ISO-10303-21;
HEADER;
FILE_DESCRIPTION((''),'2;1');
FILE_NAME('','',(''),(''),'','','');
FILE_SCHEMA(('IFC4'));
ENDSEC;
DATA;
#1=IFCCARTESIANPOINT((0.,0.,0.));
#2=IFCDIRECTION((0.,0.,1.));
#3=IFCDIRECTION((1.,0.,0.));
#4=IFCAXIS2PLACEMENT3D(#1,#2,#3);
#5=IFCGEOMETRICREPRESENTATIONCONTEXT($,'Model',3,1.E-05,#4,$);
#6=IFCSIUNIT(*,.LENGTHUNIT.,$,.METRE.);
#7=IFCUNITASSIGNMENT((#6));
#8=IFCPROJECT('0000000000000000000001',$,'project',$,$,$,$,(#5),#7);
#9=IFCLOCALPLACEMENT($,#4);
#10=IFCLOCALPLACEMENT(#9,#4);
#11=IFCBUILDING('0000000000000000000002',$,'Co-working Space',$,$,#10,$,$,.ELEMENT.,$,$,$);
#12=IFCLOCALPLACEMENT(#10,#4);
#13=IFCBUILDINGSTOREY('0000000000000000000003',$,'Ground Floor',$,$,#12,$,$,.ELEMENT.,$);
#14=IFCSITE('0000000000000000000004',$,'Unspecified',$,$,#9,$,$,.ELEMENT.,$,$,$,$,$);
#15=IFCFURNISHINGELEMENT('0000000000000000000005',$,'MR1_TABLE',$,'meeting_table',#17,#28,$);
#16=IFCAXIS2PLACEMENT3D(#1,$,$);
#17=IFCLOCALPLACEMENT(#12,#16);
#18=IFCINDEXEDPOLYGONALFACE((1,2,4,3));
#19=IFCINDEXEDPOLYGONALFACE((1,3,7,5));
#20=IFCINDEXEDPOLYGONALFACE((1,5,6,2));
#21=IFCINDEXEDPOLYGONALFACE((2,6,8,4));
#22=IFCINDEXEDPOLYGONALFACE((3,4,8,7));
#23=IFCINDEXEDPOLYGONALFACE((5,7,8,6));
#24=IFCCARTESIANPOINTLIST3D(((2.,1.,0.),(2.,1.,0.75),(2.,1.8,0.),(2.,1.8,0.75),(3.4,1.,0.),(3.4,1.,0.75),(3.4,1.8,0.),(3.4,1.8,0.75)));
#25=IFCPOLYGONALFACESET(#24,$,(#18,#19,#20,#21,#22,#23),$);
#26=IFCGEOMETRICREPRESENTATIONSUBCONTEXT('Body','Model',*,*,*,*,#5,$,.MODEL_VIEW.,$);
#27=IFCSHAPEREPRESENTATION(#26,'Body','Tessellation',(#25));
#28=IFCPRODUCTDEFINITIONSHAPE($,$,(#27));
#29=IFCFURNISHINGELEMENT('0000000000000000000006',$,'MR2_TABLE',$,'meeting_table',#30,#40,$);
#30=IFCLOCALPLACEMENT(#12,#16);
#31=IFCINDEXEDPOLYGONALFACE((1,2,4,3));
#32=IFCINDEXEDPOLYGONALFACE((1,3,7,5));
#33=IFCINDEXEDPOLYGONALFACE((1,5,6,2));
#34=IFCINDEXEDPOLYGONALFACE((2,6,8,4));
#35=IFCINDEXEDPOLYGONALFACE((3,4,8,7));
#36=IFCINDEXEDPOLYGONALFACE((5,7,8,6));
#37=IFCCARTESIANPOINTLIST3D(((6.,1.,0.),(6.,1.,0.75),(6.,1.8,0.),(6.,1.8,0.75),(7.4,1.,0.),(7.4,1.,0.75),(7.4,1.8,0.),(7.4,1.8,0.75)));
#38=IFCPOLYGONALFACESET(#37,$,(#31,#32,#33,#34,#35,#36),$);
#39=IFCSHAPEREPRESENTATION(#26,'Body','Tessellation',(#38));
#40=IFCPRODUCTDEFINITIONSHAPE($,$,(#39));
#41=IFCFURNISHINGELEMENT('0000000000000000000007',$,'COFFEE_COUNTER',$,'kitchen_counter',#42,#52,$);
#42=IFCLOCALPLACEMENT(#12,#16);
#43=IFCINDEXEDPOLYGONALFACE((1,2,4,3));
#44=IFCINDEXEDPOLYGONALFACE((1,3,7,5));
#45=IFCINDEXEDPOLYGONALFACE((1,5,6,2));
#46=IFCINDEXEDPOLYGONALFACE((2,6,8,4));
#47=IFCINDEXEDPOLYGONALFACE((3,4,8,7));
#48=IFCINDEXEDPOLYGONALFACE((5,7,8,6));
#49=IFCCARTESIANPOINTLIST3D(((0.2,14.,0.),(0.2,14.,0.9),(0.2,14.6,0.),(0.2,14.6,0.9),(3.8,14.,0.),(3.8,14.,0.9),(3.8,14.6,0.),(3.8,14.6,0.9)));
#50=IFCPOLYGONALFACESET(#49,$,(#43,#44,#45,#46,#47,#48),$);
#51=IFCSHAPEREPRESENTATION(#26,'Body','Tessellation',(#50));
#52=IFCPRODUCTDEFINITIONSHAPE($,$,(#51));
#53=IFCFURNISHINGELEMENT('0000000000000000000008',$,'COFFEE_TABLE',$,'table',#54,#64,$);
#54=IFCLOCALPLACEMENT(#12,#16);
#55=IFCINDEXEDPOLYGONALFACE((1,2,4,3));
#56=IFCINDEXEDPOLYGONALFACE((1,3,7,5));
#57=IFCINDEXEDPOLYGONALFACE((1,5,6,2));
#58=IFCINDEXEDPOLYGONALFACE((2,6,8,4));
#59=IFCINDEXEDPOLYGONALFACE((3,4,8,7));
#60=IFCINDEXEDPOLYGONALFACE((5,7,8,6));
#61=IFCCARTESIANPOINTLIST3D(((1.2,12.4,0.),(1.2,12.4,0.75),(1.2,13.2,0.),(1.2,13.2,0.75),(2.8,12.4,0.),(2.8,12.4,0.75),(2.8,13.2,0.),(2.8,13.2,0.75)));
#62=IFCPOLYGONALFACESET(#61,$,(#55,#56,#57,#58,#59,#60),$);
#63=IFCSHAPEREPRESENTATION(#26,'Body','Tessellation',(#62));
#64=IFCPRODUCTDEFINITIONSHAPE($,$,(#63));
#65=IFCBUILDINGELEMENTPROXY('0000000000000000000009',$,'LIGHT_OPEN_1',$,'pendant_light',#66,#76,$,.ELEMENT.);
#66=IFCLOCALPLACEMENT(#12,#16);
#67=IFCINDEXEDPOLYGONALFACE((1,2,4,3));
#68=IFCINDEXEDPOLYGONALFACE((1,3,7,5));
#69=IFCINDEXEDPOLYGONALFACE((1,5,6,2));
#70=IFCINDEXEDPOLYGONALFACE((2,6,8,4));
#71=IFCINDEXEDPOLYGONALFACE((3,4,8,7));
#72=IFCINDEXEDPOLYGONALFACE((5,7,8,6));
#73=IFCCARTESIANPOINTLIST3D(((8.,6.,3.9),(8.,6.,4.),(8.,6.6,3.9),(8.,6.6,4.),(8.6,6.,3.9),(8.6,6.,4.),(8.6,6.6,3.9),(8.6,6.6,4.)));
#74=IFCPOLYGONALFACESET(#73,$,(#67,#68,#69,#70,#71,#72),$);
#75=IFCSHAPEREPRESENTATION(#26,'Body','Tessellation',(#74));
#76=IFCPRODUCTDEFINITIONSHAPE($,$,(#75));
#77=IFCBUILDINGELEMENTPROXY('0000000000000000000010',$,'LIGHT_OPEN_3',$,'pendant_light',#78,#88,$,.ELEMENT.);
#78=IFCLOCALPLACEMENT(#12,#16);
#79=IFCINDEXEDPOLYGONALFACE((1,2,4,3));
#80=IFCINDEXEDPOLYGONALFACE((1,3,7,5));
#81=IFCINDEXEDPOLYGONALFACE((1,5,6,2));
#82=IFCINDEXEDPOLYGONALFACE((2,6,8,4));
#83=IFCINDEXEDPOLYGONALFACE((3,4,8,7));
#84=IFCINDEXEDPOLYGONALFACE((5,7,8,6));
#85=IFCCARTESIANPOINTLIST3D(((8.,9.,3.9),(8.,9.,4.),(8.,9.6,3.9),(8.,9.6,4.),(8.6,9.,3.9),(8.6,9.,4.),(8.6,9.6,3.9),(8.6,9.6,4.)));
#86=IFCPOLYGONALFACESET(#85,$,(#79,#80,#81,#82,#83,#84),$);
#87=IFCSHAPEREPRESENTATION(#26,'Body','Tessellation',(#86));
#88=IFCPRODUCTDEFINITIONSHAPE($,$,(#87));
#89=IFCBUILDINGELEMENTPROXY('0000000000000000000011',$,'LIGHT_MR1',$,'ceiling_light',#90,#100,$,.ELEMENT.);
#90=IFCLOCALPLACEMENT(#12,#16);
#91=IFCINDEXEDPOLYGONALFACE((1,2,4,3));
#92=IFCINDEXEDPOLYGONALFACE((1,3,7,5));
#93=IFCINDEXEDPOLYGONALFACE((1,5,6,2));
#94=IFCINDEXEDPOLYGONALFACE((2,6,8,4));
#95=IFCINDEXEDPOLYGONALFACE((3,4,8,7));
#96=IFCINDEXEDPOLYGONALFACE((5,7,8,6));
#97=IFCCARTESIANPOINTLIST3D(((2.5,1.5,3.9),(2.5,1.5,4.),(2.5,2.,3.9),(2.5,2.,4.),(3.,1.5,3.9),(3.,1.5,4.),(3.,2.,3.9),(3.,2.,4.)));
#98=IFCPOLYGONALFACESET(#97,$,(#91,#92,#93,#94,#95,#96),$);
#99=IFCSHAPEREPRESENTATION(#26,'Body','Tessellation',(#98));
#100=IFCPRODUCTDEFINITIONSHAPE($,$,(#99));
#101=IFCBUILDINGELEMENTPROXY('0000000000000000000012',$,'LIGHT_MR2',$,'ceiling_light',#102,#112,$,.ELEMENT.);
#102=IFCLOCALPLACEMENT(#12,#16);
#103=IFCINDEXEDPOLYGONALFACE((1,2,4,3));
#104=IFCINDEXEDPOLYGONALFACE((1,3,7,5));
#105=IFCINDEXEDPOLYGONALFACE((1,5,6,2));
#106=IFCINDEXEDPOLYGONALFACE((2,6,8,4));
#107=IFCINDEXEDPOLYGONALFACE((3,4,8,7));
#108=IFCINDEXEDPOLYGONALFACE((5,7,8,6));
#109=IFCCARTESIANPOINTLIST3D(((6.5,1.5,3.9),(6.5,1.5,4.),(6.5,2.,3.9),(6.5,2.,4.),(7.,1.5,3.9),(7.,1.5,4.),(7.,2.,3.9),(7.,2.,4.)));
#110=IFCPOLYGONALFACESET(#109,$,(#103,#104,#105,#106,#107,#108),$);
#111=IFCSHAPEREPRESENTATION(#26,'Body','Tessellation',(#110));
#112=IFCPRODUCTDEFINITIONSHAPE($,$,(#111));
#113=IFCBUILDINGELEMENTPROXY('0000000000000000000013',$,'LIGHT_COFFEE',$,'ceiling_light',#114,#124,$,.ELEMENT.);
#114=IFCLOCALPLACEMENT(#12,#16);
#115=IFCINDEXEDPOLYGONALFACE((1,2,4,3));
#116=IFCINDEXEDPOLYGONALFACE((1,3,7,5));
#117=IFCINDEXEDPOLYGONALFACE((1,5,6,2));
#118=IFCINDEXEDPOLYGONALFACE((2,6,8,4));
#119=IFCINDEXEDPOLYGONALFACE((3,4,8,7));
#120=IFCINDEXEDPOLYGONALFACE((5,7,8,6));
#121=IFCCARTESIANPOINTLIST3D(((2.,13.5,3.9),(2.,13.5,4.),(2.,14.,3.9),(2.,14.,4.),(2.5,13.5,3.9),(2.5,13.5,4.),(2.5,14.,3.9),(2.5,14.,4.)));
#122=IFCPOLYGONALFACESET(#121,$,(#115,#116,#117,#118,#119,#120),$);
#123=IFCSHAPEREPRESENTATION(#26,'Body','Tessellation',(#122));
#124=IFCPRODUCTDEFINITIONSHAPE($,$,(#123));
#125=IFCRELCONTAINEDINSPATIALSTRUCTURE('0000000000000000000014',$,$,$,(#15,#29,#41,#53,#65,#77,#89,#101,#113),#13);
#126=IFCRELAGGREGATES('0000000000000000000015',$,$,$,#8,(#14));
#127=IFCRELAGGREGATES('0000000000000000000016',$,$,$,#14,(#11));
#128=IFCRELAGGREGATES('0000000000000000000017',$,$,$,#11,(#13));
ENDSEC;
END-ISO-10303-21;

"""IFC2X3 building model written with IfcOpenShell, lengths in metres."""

from ifc_helpers import new_model, si_unit, frame, frame_2d, origin, origin_with_axes, place, context, subcontext, project, spatial, rectangle, extrude, element, save


model = new_model("IFC2X3")

# Units and contexts
model_context = context("Model", 3, precision=1e-05, world=origin_with_axes())
body_context = subcontext(model_context, "Body", "Model", "MODEL_VIEW")
ifc_project = project(units=[si_unit("LENGTHUNIT", "METRE")], contexts=[model_context])

# Site, building, storey
site_placement = place(None, origin_with_axes())
site = spatial("IfcSite", under=ifc_project, at=site_placement, Name="Unspecified", CompositionType="ELEMENT")
building_placement = place(site_placement, origin_with_axes())
building = spatial("IfcBuilding", under=site, at=building_placement, Name="Co-working Space", CompositionType="ELEMENT")
storey_placement = place(building_placement, origin_with_axes())
storey = spatial("IfcBuildingStorey", under=building, at=storey_placement, Name="Ground Floor", CompositionType="ELEMENT")

# Furnishing elements
for number, where, z_axis, x_axis, name in (
    (1, (2.0, 1.0, 0.0), (0.0, 0.0, 1.0), (1.0, 0.0, 0.0), "MR1_TABLE"),
    (2, (6.0, 1.0, 0.0), (0.0, 0.0, 1.0), (1.0, 0.0, 0.0), "MR2_TABLE"),
):
    element("IfcFurnishingElement", number, at=place(storey_placement, frame(where, z_axis=z_axis, x_axis=x_axis)), inside=storey, Name=name, ObjectType="meeting_table", context=body_context, shape_type="SweptSolid", body=[
        extrude(rectangle(XDim=1.4, YDim=0.8, at=frame_2d((0.7, 0.4))), origin(), (0.0, 0.0, 1.0), 0.75),
    ])
furnishing_1_placement = place(storey_placement, frame((0.2, 14.0, 0.0), z_axis=(0.0, 0.0, 1.0), x_axis=(1.0, 0.0, 0.0)))
element("IfcFurnishingElement", 3, at=furnishing_1_placement, inside=storey, Name="COFFEE_COUNTER", ObjectType="kitchen_counter", context=body_context, shape_type="SweptSolid", body=[
    extrude(rectangle(XDim=3.6, YDim=0.6, at=frame_2d((1.8, 0.3))), origin(), (0.0, 0.0, 1.0), 0.9),
])
furnishing_2_placement = place(storey_placement, frame((1.2, 12.4, 0.0), z_axis=(0.0, 0.0, 1.0), x_axis=(1.0, 0.0, 0.0)))
element("IfcFurnishingElement", 4, at=furnishing_2_placement, inside=storey, Name="COFFEE_TABLE", ObjectType="table", context=body_context, shape_type="SweptSolid", body=[
    extrude(rectangle(XDim=1.6, YDim=0.8, at=frame_2d((0.8, 0.4))), origin(), (0.0, 0.0, 1.0), 0.75),
])

# Building element proxies
for number, where, z_axis, x_axis, name in (
    (5, (8.0, 6.0, 3.9), (0.0, 0.0, 1.0), (1.0, 0.0, 0.0), "LIGHT_OPEN_1"),
    (6, (8.0, 9.0, 3.9), (0.0, 0.0, 1.0), (1.0, 0.0, 0.0), "LIGHT_OPEN_3"),
):
    element("IfcBuildingElementProxy", number, at=place(storey_placement, frame(where, z_axis=z_axis, x_axis=x_axis)), inside=storey, Name=name, ObjectType="pendant_light", CompositionType="ELEMENT", context=body_context, shape_type="SweptSolid", body=[
        extrude(rectangle(XDim=0.6, YDim=0.6, at=frame_2d((0.3, 0.3))), origin(), (0.0, 0.0, 1.0), 0.1),
    ])
for number, where, z_axis, x_axis, name in (
    (7, (2.5, 1.5, 3.9), (0.0, 0.0, 1.0), (1.0, 0.0, 0.0), "LIGHT_MR1"),
    (8, (6.5, 1.5, 3.9), (0.0, 0.0, 1.0), (1.0, 0.0, 0.0), "LIGHT_MR2"),
    (9, (2.0, 13.5, 3.9), (0.0, 0.0, 1.0), (1.0, 0.0, 0.0), "LIGHT_COFFEE"),
):
    element("IfcBuildingElementProxy", number, at=place(storey_placement, frame(where, z_axis=z_axis, x_axis=x_axis)), inside=storey, Name=name, ObjectType="ceiling_light", CompositionType="ELEMENT", context=body_context, shape_type="SweptSolid", body=[
        extrude(rectangle(XDim=0.5, YDim=0.5, at=frame_2d((0.25, 0.25))), origin(), (0.0, 0.0, 1.0), 0.1),
    ])

save(model, "model.ifc")
